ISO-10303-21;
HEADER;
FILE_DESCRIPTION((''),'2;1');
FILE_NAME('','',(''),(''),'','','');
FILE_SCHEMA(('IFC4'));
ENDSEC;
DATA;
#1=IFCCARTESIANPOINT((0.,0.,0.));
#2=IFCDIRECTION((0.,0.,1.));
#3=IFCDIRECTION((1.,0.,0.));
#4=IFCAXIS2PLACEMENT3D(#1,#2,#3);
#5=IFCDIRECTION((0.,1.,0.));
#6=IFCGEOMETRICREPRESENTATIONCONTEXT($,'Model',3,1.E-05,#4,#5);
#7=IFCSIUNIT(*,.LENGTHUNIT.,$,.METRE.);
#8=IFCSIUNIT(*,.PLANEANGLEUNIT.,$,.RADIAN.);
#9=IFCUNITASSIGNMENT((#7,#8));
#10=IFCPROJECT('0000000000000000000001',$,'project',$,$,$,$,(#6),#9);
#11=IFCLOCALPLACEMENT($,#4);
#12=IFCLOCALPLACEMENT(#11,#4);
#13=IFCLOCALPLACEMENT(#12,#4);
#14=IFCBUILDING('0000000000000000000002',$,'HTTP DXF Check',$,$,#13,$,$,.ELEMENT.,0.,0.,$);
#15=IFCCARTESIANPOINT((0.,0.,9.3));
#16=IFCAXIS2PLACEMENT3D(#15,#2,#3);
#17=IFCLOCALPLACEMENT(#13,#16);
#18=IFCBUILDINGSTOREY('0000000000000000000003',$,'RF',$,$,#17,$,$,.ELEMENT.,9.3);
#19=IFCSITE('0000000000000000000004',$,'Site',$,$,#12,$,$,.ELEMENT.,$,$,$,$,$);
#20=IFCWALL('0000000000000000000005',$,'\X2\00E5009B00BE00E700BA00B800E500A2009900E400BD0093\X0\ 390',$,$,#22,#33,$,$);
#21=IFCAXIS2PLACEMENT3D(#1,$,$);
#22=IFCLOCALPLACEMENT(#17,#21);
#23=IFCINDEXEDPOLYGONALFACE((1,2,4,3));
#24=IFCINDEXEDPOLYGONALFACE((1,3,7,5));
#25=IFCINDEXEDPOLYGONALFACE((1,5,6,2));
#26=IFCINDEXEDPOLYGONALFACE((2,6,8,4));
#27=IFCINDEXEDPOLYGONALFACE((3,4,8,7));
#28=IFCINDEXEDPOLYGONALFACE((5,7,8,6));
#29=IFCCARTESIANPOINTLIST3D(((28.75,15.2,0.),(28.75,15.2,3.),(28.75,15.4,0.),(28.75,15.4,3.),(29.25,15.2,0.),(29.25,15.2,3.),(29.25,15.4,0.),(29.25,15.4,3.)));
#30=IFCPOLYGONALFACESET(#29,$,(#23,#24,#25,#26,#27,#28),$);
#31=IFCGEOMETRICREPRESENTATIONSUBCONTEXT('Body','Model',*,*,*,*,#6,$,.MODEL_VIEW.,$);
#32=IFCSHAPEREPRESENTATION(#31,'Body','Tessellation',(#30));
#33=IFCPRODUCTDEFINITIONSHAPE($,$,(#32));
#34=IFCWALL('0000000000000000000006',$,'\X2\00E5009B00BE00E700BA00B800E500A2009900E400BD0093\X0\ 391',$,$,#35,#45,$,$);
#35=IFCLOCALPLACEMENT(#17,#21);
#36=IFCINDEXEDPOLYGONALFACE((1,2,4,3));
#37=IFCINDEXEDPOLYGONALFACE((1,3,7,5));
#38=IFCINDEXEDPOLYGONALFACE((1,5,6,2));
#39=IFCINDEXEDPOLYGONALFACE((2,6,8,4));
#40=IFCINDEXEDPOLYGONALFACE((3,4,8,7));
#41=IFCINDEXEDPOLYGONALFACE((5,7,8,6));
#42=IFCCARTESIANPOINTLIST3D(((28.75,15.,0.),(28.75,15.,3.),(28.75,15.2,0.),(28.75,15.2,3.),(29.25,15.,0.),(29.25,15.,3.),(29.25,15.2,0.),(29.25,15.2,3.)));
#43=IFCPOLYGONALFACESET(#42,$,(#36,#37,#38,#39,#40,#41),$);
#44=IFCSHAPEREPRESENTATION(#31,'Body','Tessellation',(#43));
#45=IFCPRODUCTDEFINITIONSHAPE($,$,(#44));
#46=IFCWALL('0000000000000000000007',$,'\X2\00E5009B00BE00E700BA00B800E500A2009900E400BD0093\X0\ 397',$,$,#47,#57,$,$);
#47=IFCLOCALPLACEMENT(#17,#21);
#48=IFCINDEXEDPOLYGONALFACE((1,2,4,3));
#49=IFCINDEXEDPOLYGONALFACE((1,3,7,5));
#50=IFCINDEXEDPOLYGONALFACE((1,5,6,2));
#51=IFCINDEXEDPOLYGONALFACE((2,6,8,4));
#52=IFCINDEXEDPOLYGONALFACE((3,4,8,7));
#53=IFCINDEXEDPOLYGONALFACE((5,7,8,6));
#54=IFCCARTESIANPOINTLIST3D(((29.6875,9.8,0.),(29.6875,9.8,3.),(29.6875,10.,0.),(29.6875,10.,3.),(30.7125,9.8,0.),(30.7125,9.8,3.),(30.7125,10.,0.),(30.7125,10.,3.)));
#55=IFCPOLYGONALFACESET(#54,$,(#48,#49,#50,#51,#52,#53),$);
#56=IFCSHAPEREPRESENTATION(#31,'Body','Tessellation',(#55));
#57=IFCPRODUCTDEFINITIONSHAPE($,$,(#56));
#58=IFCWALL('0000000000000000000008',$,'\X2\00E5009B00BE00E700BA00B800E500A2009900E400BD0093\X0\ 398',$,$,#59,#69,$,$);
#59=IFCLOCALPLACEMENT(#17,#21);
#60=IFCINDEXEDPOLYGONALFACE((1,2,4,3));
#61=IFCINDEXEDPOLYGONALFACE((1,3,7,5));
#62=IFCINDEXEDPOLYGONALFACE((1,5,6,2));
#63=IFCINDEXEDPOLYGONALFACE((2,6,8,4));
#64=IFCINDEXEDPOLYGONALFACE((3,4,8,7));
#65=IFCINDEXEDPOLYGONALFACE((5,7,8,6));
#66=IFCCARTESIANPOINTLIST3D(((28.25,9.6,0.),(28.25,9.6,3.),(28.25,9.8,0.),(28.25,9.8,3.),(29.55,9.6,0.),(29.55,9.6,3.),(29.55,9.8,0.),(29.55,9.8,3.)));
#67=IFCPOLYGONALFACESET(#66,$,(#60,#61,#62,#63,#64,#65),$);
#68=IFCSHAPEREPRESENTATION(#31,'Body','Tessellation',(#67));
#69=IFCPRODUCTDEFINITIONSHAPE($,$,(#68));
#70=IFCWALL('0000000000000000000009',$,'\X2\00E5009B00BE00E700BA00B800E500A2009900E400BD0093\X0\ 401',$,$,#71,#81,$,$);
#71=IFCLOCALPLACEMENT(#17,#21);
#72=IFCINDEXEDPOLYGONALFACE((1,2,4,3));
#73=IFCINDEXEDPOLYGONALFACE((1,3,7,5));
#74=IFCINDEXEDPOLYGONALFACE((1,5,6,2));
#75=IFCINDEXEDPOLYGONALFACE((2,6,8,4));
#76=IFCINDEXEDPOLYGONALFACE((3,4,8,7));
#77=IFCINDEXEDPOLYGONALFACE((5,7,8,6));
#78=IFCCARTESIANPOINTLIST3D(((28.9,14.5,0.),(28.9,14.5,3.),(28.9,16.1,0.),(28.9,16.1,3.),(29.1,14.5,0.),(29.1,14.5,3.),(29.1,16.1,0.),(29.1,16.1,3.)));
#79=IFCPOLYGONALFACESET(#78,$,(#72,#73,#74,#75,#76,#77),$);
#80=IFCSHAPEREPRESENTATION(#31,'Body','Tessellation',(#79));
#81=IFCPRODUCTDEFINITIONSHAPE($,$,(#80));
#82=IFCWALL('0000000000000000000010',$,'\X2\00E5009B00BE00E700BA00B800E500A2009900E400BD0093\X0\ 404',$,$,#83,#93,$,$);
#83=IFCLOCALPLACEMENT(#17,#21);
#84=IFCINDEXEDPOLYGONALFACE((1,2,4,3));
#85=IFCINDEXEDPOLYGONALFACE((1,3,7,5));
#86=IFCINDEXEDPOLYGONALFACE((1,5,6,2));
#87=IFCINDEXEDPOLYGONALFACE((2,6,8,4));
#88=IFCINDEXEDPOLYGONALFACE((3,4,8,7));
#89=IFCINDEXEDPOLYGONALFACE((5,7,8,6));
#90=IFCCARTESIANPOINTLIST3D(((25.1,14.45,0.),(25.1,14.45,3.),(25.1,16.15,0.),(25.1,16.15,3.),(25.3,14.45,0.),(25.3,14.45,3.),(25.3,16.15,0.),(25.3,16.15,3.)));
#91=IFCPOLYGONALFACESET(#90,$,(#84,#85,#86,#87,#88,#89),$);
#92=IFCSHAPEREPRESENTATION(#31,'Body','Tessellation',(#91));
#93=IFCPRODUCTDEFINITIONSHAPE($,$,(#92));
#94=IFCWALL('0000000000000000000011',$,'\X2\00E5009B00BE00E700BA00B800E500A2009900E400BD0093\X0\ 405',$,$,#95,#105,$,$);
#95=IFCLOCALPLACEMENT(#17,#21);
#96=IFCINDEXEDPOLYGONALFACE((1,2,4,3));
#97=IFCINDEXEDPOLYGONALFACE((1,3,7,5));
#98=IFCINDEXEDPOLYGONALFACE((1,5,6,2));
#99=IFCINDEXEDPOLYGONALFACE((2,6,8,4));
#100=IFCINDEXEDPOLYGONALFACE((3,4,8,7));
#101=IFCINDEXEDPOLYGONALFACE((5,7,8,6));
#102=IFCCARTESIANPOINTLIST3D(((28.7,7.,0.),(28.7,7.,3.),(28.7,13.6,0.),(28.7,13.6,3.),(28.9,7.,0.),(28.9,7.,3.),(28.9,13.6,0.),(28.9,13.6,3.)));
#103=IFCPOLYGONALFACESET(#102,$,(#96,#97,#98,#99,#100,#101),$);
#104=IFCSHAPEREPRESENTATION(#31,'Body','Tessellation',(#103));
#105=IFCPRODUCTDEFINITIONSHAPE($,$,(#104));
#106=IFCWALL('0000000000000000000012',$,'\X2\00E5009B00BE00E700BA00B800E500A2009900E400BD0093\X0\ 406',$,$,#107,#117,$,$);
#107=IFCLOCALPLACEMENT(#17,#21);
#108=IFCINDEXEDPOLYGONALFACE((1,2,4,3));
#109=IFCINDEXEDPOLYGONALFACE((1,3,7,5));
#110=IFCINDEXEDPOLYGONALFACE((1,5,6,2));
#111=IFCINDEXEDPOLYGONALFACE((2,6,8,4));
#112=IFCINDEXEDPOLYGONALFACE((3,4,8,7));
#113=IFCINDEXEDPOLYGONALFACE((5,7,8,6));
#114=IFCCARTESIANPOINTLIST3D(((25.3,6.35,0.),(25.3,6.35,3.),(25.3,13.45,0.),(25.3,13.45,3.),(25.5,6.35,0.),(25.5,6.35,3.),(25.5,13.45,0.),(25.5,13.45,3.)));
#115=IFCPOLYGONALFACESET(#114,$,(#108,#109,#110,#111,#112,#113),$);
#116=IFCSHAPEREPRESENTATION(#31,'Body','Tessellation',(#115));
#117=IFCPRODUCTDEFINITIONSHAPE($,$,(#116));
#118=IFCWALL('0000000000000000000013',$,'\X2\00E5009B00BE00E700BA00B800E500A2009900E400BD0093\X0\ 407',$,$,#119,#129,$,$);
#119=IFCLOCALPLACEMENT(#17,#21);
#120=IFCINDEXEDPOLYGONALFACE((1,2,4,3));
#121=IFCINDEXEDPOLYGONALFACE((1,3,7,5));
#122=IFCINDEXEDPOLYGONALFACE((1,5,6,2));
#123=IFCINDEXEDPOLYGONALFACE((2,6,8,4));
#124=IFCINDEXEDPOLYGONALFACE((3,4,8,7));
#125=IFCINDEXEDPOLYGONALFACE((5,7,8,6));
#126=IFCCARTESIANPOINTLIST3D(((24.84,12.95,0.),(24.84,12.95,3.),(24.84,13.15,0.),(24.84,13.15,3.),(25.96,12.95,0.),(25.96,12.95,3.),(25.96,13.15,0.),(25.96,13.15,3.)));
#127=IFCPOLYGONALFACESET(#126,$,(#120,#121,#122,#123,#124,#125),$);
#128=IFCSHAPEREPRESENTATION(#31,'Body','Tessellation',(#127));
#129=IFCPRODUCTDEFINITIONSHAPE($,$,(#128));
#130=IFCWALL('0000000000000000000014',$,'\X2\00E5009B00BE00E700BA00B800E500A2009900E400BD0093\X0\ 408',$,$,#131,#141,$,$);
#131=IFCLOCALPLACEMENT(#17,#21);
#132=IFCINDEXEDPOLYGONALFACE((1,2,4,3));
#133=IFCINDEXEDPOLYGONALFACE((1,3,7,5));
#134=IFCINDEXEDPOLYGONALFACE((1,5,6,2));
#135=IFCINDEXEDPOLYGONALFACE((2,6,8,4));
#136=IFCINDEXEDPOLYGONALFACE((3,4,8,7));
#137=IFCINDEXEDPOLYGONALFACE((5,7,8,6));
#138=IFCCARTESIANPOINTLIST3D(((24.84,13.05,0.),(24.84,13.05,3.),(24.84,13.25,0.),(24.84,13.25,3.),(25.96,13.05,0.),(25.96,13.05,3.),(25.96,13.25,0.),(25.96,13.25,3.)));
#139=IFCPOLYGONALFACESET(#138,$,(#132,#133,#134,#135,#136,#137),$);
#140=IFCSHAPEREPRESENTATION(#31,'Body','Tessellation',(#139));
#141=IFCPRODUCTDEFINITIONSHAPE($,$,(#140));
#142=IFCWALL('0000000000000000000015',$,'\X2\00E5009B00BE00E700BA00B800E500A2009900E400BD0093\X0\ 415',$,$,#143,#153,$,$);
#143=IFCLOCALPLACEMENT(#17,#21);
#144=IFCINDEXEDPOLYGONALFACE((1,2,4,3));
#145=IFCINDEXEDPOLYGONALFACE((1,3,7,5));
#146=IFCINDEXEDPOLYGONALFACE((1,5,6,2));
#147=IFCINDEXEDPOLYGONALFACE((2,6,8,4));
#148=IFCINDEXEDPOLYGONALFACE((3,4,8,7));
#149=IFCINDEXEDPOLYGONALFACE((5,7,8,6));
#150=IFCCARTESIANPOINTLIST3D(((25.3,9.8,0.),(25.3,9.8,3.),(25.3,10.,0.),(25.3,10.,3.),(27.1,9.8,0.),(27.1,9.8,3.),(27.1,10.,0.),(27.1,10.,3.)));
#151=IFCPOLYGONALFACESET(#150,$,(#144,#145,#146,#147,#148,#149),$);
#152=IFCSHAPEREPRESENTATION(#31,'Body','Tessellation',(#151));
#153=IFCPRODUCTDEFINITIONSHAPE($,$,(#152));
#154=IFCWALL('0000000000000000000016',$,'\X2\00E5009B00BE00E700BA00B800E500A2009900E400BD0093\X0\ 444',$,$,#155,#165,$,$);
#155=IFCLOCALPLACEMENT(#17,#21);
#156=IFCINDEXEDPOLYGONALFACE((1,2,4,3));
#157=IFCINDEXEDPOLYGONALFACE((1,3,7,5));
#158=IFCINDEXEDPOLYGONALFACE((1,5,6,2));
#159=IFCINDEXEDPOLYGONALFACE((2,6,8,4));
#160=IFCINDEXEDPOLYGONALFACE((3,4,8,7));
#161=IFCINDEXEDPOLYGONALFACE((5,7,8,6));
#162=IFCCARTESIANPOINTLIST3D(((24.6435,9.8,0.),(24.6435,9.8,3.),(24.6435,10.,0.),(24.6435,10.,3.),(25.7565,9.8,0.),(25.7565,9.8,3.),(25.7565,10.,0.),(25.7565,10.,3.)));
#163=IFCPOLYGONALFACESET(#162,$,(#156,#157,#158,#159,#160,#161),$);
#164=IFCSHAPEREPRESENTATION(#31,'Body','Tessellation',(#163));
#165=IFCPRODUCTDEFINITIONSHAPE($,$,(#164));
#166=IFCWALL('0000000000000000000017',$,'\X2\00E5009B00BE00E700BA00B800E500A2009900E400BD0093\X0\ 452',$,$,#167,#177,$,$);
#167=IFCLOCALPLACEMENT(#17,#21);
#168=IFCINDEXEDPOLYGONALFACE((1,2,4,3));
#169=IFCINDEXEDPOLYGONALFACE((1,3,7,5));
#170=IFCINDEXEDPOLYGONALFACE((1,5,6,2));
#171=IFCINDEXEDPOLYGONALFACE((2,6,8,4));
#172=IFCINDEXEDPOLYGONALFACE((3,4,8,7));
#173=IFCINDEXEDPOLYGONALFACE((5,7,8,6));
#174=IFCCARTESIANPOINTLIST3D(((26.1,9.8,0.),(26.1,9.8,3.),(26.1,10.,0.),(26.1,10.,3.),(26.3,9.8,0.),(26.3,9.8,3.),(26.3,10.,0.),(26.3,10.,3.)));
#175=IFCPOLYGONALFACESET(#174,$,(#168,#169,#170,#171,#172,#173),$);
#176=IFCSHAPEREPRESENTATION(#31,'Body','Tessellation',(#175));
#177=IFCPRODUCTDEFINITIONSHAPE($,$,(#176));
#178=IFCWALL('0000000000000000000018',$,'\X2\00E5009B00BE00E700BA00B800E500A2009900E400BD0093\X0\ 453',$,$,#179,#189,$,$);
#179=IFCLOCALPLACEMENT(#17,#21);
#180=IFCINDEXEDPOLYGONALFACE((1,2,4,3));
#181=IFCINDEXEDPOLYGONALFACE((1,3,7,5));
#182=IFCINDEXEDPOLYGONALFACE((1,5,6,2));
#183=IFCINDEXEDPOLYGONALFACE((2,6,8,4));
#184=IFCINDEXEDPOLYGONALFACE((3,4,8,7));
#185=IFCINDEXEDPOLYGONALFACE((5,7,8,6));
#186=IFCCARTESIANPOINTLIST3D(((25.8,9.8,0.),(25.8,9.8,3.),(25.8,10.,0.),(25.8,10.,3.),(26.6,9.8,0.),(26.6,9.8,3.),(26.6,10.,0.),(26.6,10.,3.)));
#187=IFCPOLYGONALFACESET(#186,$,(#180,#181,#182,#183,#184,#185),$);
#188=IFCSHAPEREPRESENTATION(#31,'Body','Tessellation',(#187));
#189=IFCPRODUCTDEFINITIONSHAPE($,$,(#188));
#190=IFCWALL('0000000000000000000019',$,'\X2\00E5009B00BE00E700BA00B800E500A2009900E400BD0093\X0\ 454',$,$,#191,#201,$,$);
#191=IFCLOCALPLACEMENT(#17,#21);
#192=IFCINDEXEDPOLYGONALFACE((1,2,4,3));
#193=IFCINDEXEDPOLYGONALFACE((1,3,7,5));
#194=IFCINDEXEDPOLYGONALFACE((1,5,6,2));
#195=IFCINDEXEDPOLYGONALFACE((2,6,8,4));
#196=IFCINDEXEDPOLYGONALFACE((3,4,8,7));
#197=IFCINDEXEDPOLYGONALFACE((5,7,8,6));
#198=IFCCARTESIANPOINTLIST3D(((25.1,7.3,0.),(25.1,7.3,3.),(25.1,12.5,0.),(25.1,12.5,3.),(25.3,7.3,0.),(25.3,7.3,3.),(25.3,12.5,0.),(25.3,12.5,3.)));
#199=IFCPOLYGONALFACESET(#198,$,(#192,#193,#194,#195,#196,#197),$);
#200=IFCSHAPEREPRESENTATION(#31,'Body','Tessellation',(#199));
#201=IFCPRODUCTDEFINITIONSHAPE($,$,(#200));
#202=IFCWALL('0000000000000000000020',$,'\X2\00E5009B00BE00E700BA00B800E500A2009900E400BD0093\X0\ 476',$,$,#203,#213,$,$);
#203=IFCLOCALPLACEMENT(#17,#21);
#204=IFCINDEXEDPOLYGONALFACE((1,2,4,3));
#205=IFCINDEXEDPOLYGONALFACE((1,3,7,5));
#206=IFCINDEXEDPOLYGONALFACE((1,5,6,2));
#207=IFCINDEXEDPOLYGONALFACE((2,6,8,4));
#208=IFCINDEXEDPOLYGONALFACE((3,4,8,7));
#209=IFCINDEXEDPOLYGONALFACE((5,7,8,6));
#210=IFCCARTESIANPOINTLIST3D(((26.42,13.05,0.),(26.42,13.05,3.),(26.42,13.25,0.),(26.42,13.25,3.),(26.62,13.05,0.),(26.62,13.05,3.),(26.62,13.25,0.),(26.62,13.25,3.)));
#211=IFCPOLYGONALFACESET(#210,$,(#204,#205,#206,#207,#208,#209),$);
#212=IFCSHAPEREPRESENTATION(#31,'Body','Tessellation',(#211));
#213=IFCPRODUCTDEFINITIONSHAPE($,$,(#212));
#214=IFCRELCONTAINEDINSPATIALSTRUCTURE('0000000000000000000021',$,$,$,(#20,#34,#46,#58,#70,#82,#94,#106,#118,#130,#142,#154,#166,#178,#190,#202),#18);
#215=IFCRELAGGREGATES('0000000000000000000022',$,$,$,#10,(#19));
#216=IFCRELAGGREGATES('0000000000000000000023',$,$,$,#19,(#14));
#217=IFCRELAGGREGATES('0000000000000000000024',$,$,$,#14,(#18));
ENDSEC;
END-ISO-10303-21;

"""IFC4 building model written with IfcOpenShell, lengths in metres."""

from ifc_helpers import new_model, si_unit, direction, frame, frame_2d, origin_with_axes, place, context, subcontext, project, spatial, rectangle, extrude, element, save


model = new_model("IFC4")

# Units and contexts
model_context = context("Model", 3, precision=1e-05, world=origin_with_axes(), true_north=direction((0.0, 1.0, 0.0)))
body_context = subcontext(model_context, "Body", "Model", "MODEL_VIEW")
ifc_project = project(units=[si_unit("LENGTHUNIT", "METRE"), si_unit("PLANEANGLEUNIT", "RADIAN")], contexts=[model_context])

# Site, building, storey
placement = place(None, origin_with_axes())
site_placement = place(placement, origin_with_axes())
site = spatial("IfcSite", under=ifc_project, at=site_placement, Name="Site", CompositionType="ELEMENT")
building_placement = place(site_placement, origin_with_axes())
building = spatial("IfcBuilding", under=site, at=building_placement, Name="HTTP DXF Check", CompositionType="ELEMENT", ElevationOfRefHeight=0.0, ElevationOfTerrain=0.0)
storey_placement = place(building_placement, frame((0.0, 0.0, 9.3), z_axis=(0.0, 0.0, 1.0), x_axis=(1.0, 0.0, 0.0)))
storey = spatial("IfcBuildingStorey", under=building, at=storey_placement, Name="RF", CompositionType="ELEMENT", Elevation=9.3)

# Walls
for number, where, z_axis, x_axis, name in (
    (1, (29.0, 15.3, 0.0), (0.0, 0.0, 1.0), (1.0, 0.0, 0.0), "å\u009b¾çº¸å¢\u0099ä½\u0093 390"),
    (2, (29.0, 15.1, 0.0), (0.0, 0.0, 1.0), (1.0, 0.0, 0.0), "å\u009b¾çº¸å¢\u0099ä½\u0093 391"),
):
    element("IfcWall", number, at=place(storey_placement, frame(where, z_axis=z_axis, x_axis=x_axis)), inside=storey, Name=name, context=body_context, shape_type="SweptSolid", body=[
        extrude(rectangle(XDim=0.5, YDim=0.2, at=frame_2d((0.0, 0.0), x_axis=(1.0, 0.0, 0.0))), frame((0.0, 0.0, 0.0), z_axis=(0.0, 0.0, 1.0)), (0.0, 0.0, 1.0), 3.0),
    ])
wall_1_placement = place(storey_placement, frame((30.2, 9.9, 0.0), z_axis=(0.0, 0.0, 1.0), x_axis=(-1.0, 0.0, 0.0)))
element("IfcWall", 3, at=wall_1_placement, inside=storey, Name="å\u009b¾çº¸å¢\u0099ä½\u0093 397", context=body_context, shape_type="SweptSolid", body=[
    extrude(rectangle(XDim=1.025, YDim=0.2, at=frame_2d((0.0, 0.0), x_axis=(1.0, 0.0, 0.0))), frame((0.0, 0.0, 0.0), z_axis=(0.0, 0.0, 1.0)), (0.0, 0.0, 1.0), 3.0),
])
wall_2_placement = place(storey_placement, frame((28.9, 9.7, 0.0), z_axis=(0.0, 0.0, 1.0), x_axis=(1.0, 0.0, 0.0)))
element("IfcWall", 4, at=wall_2_placement, inside=storey, Name="å\u009b¾çº¸å¢\u0099ä½\u0093 398", context=body_context, shape_type="SweptSolid", body=[
    extrude(rectangle(XDim=1.3, YDim=0.2, at=frame_2d((0.0, 0.0), x_axis=(1.0, 0.0, 0.0))), frame((0.0, 0.0, 0.0), z_axis=(0.0, 0.0, 1.0)), (0.0, 0.0, 1.0), 3.0),
])
wall_3_placement = place(storey_placement, frame((29.0, 15.3, 0.0), z_axis=(0.0, 0.0, 1.0), x_axis=(0.0, 1.0, 0.0)))
element("IfcWall", 5, at=wall_3_placement, inside=storey, Name="å\u009b¾çº¸å¢\u0099ä½\u0093 401", context=body_context, shape_type="SweptSolid", body=[
    extrude(rectangle(XDim=1.6, YDim=0.2, at=frame_2d((0.0, 0.0), x_axis=(1.0, 0.0, 0.0))), frame((0.0, 0.0, 0.0), z_axis=(0.0, 0.0, 1.0)), (0.0, 0.0, 1.0), 3.0),
])
wall_4_placement = place(storey_placement, frame((25.2, 15.3, 0.0), z_axis=(0.0, 0.0, 1.0), x_axis=(0.0, 1.0, 0.0)))
element("IfcWall", 6, at=wall_4_placement, inside=storey, Name="å\u009b¾çº¸å¢\u0099ä½\u0093 404", context=body_context, shape_type="SweptSolid", body=[
    extrude(rectangle(XDim=1.7, YDim=0.2, at=frame_2d((0.0, 0.0), x_axis=(1.0, 0.0, 0.0))), frame((0.0, 0.0, 0.0), z_axis=(0.0, 0.0, 1.0)), (0.0, 0.0, 1.0), 3.0),
])
wall_5_placement = place(storey_placement, frame((28.8, 10.3, 0.0), z_axis=(0.0, 0.0, 1.0), x_axis=(0.0, 1.0, 0.0)))
element("IfcWall", 7, at=wall_5_placement, inside=storey, Name="å\u009b¾çº¸å¢\u0099ä½\u0093 405", context=body_context, shape_type="SweptSolid", body=[
    extrude(rectangle(XDim=6.6, YDim=0.2, at=frame_2d((0.0, 0.0), x_axis=(1.0, 0.0, 0.0))), frame((0.0, 0.0, 0.0), z_axis=(0.0, 0.0, 1.0)), (0.0, 0.0, 1.0), 3.0),
])
wall_6_placement = place(storey_placement, frame((25.4, 9.9, 0.0), z_axis=(0.0, 0.0, 1.0), x_axis=(0.0, 1.0, 0.0)))
element("IfcWall", 8, at=wall_6_placement, inside=storey, Name="å\u009b¾çº¸å¢\u0099ä½\u0093 406", context=body_context, shape_type="SweptSolid", body=[
    extrude(rectangle(XDim=7.1, YDim=0.2, at=frame_2d((0.0, 0.0), x_axis=(1.0, 0.0, 0.0))), frame((0.0, 0.0, 0.0), z_axis=(0.0, 0.0, 1.0)), (0.0, 0.0, 1.0), 3.0),
])
for number, where, z_axis, x_axis, name in (
    (9, (25.4, 13.05, 0.0), (0.0, 0.0, 1.0), (1.0, 0.0, 0.0), "å\u009b¾çº¸å¢\u0099ä½\u0093 407"),
    (10, (25.4, 13.15, 0.0), (0.0, 0.0, 1.0), (1.0, 0.0, 0.0), "å\u009b¾çº¸å¢\u0099ä½\u0093 408"),
):
    element("IfcWall", number, at=place(storey_placement, frame(where, z_axis=z_axis, x_axis=x_axis)), inside=storey, Name=name, context=body_context, shape_type="SweptSolid", body=[
        extrude(rectangle(XDim=1.12, YDim=0.2, at=frame_2d((0.0, 0.0), x_axis=(1.0, 0.0, 0.0))), frame((0.0, 0.0, 0.0), z_axis=(0.0, 0.0, 1.0)), (0.0, 0.0, 1.0), 3.0),
    ])
wall_7_placement = place(storey_placement, frame((26.2, 9.9, 0.0), z_axis=(0.0, 0.0, 1.0), x_axis=(1.0, 0.0, 0.0)))
element("IfcWall", 11, at=wall_7_placement, inside=storey, Name="å\u009b¾çº¸å¢\u0099ä½\u0093 415", context=body_context, shape_type="SweptSolid", body=[
    extrude(rectangle(XDim=1.8, YDim=0.2, at=frame_2d((0.0, 0.0), x_axis=(1.0, 0.0, 0.0))), frame((0.0, 0.0, 0.0), z_axis=(0.0, 0.0, 1.0)), (0.0, 0.0, 1.0), 3.0),
])
wall_8_placement = place(storey_placement, frame((25.2, 9.9, 0.0), z_axis=(0.0, 0.0, 1.0), x_axis=(-1.0, 0.0, 0.0)))
element("IfcWall", 12, at=wall_8_placement, inside=storey, Name="å\u009b¾çº¸å¢\u0099ä½\u0093 444", context=body_context, shape_type="SweptSolid", body=[
    extrude(rectangle(XDim=1.113, YDim=0.2, at=frame_2d((0.0, 0.0), x_axis=(1.0, 0.0, 0.0))), frame((0.0, 0.0, 0.0), z_axis=(0.0, 0.0, 1.0)), (0.0, 0.0, 1.0), 3.0),
])
wall_9_placement = place(storey_placement, frame((26.2, 9.9, 0.0), z_axis=(0.0, 0.0, 1.0), x_axis=(0.0, -1.0, 0.0)))
element("IfcWall", 13, at=wall_9_placement, inside=storey, Name="å\u009b¾çº¸å¢\u0099ä½\u0093 452", context=body_context, shape_type="SweptSolid", body=[
    extrude(rectangle(XDim=0.2, YDim=0.2, at=frame_2d((0.0, 0.0), x_axis=(1.0, 0.0, 0.0))), frame((0.0, 0.0, 0.0), z_axis=(0.0, 0.0, 1.0)), (0.0, 0.0, 1.0), 3.0),
])
wall_10_placement = place(storey_placement, frame((26.2, 9.9, 0.0), z_axis=(0.0, 0.0, 1.0), x_axis=(-1.0, 0.0, 0.0)))
element("IfcWall", 14, at=wall_10_placement, inside=storey, Name="å\u009b¾çº¸å¢\u0099ä½\u0093 453", context=body_context, shape_type="SweptSolid", body=[
    extrude(rectangle(XDim=0.8, YDim=0.2, at=frame_2d((0.0, 0.0), x_axis=(1.0, 0.0, 0.0))), frame((0.0, 0.0, 0.0), z_axis=(0.0, 0.0, 1.0)), (0.0, 0.0, 1.0), 3.0),
])
wall_11_placement = place(storey_placement, frame((25.2, 9.9, 0.0), z_axis=(0.0, 0.0, 1.0), x_axis=(0.0, 1.0, 0.0)))
element("IfcWall", 15, at=wall_11_placement, inside=storey, Name="å\u009b¾çº¸å¢\u0099ä½\u0093 454", context=body_context, shape_type="SweptSolid", body=[
    extrude(rectangle(XDim=5.2, YDim=0.2, at=frame_2d((0.0, 0.0), x_axis=(1.0, 0.0, 0.0))), frame((0.0, 0.0, 0.0), z_axis=(0.0, 0.0, 1.0)), (0.0, 0.0, 1.0), 3.0),
])
for number, where, z_axis, x_axis, name in (
    (16, (26.52, 13.15, 0.0), (0.0, 0.0, 1.0), (0.0, -1.0, 0.0), "å\u009b¾çº¸å¢\u0099ä½\u0093 476"),
):
    element("IfcWall", number, at=place(storey_placement, frame(where, z_axis=z_axis, x_axis=x_axis)), inside=storey, Name=name, context=body_context, shape_type="SweptSolid", body=[
        extrude(rectangle(XDim=0.2, YDim=0.2, at=frame_2d((0.0, 0.0), x_axis=(1.0, 0.0, 0.0))), frame((0.0, 0.0, 0.0), z_axis=(0.0, 0.0, 1.0)), (0.0, 0.0, 1.0), 3.0),
    ])

save(model, "model.ifc")
